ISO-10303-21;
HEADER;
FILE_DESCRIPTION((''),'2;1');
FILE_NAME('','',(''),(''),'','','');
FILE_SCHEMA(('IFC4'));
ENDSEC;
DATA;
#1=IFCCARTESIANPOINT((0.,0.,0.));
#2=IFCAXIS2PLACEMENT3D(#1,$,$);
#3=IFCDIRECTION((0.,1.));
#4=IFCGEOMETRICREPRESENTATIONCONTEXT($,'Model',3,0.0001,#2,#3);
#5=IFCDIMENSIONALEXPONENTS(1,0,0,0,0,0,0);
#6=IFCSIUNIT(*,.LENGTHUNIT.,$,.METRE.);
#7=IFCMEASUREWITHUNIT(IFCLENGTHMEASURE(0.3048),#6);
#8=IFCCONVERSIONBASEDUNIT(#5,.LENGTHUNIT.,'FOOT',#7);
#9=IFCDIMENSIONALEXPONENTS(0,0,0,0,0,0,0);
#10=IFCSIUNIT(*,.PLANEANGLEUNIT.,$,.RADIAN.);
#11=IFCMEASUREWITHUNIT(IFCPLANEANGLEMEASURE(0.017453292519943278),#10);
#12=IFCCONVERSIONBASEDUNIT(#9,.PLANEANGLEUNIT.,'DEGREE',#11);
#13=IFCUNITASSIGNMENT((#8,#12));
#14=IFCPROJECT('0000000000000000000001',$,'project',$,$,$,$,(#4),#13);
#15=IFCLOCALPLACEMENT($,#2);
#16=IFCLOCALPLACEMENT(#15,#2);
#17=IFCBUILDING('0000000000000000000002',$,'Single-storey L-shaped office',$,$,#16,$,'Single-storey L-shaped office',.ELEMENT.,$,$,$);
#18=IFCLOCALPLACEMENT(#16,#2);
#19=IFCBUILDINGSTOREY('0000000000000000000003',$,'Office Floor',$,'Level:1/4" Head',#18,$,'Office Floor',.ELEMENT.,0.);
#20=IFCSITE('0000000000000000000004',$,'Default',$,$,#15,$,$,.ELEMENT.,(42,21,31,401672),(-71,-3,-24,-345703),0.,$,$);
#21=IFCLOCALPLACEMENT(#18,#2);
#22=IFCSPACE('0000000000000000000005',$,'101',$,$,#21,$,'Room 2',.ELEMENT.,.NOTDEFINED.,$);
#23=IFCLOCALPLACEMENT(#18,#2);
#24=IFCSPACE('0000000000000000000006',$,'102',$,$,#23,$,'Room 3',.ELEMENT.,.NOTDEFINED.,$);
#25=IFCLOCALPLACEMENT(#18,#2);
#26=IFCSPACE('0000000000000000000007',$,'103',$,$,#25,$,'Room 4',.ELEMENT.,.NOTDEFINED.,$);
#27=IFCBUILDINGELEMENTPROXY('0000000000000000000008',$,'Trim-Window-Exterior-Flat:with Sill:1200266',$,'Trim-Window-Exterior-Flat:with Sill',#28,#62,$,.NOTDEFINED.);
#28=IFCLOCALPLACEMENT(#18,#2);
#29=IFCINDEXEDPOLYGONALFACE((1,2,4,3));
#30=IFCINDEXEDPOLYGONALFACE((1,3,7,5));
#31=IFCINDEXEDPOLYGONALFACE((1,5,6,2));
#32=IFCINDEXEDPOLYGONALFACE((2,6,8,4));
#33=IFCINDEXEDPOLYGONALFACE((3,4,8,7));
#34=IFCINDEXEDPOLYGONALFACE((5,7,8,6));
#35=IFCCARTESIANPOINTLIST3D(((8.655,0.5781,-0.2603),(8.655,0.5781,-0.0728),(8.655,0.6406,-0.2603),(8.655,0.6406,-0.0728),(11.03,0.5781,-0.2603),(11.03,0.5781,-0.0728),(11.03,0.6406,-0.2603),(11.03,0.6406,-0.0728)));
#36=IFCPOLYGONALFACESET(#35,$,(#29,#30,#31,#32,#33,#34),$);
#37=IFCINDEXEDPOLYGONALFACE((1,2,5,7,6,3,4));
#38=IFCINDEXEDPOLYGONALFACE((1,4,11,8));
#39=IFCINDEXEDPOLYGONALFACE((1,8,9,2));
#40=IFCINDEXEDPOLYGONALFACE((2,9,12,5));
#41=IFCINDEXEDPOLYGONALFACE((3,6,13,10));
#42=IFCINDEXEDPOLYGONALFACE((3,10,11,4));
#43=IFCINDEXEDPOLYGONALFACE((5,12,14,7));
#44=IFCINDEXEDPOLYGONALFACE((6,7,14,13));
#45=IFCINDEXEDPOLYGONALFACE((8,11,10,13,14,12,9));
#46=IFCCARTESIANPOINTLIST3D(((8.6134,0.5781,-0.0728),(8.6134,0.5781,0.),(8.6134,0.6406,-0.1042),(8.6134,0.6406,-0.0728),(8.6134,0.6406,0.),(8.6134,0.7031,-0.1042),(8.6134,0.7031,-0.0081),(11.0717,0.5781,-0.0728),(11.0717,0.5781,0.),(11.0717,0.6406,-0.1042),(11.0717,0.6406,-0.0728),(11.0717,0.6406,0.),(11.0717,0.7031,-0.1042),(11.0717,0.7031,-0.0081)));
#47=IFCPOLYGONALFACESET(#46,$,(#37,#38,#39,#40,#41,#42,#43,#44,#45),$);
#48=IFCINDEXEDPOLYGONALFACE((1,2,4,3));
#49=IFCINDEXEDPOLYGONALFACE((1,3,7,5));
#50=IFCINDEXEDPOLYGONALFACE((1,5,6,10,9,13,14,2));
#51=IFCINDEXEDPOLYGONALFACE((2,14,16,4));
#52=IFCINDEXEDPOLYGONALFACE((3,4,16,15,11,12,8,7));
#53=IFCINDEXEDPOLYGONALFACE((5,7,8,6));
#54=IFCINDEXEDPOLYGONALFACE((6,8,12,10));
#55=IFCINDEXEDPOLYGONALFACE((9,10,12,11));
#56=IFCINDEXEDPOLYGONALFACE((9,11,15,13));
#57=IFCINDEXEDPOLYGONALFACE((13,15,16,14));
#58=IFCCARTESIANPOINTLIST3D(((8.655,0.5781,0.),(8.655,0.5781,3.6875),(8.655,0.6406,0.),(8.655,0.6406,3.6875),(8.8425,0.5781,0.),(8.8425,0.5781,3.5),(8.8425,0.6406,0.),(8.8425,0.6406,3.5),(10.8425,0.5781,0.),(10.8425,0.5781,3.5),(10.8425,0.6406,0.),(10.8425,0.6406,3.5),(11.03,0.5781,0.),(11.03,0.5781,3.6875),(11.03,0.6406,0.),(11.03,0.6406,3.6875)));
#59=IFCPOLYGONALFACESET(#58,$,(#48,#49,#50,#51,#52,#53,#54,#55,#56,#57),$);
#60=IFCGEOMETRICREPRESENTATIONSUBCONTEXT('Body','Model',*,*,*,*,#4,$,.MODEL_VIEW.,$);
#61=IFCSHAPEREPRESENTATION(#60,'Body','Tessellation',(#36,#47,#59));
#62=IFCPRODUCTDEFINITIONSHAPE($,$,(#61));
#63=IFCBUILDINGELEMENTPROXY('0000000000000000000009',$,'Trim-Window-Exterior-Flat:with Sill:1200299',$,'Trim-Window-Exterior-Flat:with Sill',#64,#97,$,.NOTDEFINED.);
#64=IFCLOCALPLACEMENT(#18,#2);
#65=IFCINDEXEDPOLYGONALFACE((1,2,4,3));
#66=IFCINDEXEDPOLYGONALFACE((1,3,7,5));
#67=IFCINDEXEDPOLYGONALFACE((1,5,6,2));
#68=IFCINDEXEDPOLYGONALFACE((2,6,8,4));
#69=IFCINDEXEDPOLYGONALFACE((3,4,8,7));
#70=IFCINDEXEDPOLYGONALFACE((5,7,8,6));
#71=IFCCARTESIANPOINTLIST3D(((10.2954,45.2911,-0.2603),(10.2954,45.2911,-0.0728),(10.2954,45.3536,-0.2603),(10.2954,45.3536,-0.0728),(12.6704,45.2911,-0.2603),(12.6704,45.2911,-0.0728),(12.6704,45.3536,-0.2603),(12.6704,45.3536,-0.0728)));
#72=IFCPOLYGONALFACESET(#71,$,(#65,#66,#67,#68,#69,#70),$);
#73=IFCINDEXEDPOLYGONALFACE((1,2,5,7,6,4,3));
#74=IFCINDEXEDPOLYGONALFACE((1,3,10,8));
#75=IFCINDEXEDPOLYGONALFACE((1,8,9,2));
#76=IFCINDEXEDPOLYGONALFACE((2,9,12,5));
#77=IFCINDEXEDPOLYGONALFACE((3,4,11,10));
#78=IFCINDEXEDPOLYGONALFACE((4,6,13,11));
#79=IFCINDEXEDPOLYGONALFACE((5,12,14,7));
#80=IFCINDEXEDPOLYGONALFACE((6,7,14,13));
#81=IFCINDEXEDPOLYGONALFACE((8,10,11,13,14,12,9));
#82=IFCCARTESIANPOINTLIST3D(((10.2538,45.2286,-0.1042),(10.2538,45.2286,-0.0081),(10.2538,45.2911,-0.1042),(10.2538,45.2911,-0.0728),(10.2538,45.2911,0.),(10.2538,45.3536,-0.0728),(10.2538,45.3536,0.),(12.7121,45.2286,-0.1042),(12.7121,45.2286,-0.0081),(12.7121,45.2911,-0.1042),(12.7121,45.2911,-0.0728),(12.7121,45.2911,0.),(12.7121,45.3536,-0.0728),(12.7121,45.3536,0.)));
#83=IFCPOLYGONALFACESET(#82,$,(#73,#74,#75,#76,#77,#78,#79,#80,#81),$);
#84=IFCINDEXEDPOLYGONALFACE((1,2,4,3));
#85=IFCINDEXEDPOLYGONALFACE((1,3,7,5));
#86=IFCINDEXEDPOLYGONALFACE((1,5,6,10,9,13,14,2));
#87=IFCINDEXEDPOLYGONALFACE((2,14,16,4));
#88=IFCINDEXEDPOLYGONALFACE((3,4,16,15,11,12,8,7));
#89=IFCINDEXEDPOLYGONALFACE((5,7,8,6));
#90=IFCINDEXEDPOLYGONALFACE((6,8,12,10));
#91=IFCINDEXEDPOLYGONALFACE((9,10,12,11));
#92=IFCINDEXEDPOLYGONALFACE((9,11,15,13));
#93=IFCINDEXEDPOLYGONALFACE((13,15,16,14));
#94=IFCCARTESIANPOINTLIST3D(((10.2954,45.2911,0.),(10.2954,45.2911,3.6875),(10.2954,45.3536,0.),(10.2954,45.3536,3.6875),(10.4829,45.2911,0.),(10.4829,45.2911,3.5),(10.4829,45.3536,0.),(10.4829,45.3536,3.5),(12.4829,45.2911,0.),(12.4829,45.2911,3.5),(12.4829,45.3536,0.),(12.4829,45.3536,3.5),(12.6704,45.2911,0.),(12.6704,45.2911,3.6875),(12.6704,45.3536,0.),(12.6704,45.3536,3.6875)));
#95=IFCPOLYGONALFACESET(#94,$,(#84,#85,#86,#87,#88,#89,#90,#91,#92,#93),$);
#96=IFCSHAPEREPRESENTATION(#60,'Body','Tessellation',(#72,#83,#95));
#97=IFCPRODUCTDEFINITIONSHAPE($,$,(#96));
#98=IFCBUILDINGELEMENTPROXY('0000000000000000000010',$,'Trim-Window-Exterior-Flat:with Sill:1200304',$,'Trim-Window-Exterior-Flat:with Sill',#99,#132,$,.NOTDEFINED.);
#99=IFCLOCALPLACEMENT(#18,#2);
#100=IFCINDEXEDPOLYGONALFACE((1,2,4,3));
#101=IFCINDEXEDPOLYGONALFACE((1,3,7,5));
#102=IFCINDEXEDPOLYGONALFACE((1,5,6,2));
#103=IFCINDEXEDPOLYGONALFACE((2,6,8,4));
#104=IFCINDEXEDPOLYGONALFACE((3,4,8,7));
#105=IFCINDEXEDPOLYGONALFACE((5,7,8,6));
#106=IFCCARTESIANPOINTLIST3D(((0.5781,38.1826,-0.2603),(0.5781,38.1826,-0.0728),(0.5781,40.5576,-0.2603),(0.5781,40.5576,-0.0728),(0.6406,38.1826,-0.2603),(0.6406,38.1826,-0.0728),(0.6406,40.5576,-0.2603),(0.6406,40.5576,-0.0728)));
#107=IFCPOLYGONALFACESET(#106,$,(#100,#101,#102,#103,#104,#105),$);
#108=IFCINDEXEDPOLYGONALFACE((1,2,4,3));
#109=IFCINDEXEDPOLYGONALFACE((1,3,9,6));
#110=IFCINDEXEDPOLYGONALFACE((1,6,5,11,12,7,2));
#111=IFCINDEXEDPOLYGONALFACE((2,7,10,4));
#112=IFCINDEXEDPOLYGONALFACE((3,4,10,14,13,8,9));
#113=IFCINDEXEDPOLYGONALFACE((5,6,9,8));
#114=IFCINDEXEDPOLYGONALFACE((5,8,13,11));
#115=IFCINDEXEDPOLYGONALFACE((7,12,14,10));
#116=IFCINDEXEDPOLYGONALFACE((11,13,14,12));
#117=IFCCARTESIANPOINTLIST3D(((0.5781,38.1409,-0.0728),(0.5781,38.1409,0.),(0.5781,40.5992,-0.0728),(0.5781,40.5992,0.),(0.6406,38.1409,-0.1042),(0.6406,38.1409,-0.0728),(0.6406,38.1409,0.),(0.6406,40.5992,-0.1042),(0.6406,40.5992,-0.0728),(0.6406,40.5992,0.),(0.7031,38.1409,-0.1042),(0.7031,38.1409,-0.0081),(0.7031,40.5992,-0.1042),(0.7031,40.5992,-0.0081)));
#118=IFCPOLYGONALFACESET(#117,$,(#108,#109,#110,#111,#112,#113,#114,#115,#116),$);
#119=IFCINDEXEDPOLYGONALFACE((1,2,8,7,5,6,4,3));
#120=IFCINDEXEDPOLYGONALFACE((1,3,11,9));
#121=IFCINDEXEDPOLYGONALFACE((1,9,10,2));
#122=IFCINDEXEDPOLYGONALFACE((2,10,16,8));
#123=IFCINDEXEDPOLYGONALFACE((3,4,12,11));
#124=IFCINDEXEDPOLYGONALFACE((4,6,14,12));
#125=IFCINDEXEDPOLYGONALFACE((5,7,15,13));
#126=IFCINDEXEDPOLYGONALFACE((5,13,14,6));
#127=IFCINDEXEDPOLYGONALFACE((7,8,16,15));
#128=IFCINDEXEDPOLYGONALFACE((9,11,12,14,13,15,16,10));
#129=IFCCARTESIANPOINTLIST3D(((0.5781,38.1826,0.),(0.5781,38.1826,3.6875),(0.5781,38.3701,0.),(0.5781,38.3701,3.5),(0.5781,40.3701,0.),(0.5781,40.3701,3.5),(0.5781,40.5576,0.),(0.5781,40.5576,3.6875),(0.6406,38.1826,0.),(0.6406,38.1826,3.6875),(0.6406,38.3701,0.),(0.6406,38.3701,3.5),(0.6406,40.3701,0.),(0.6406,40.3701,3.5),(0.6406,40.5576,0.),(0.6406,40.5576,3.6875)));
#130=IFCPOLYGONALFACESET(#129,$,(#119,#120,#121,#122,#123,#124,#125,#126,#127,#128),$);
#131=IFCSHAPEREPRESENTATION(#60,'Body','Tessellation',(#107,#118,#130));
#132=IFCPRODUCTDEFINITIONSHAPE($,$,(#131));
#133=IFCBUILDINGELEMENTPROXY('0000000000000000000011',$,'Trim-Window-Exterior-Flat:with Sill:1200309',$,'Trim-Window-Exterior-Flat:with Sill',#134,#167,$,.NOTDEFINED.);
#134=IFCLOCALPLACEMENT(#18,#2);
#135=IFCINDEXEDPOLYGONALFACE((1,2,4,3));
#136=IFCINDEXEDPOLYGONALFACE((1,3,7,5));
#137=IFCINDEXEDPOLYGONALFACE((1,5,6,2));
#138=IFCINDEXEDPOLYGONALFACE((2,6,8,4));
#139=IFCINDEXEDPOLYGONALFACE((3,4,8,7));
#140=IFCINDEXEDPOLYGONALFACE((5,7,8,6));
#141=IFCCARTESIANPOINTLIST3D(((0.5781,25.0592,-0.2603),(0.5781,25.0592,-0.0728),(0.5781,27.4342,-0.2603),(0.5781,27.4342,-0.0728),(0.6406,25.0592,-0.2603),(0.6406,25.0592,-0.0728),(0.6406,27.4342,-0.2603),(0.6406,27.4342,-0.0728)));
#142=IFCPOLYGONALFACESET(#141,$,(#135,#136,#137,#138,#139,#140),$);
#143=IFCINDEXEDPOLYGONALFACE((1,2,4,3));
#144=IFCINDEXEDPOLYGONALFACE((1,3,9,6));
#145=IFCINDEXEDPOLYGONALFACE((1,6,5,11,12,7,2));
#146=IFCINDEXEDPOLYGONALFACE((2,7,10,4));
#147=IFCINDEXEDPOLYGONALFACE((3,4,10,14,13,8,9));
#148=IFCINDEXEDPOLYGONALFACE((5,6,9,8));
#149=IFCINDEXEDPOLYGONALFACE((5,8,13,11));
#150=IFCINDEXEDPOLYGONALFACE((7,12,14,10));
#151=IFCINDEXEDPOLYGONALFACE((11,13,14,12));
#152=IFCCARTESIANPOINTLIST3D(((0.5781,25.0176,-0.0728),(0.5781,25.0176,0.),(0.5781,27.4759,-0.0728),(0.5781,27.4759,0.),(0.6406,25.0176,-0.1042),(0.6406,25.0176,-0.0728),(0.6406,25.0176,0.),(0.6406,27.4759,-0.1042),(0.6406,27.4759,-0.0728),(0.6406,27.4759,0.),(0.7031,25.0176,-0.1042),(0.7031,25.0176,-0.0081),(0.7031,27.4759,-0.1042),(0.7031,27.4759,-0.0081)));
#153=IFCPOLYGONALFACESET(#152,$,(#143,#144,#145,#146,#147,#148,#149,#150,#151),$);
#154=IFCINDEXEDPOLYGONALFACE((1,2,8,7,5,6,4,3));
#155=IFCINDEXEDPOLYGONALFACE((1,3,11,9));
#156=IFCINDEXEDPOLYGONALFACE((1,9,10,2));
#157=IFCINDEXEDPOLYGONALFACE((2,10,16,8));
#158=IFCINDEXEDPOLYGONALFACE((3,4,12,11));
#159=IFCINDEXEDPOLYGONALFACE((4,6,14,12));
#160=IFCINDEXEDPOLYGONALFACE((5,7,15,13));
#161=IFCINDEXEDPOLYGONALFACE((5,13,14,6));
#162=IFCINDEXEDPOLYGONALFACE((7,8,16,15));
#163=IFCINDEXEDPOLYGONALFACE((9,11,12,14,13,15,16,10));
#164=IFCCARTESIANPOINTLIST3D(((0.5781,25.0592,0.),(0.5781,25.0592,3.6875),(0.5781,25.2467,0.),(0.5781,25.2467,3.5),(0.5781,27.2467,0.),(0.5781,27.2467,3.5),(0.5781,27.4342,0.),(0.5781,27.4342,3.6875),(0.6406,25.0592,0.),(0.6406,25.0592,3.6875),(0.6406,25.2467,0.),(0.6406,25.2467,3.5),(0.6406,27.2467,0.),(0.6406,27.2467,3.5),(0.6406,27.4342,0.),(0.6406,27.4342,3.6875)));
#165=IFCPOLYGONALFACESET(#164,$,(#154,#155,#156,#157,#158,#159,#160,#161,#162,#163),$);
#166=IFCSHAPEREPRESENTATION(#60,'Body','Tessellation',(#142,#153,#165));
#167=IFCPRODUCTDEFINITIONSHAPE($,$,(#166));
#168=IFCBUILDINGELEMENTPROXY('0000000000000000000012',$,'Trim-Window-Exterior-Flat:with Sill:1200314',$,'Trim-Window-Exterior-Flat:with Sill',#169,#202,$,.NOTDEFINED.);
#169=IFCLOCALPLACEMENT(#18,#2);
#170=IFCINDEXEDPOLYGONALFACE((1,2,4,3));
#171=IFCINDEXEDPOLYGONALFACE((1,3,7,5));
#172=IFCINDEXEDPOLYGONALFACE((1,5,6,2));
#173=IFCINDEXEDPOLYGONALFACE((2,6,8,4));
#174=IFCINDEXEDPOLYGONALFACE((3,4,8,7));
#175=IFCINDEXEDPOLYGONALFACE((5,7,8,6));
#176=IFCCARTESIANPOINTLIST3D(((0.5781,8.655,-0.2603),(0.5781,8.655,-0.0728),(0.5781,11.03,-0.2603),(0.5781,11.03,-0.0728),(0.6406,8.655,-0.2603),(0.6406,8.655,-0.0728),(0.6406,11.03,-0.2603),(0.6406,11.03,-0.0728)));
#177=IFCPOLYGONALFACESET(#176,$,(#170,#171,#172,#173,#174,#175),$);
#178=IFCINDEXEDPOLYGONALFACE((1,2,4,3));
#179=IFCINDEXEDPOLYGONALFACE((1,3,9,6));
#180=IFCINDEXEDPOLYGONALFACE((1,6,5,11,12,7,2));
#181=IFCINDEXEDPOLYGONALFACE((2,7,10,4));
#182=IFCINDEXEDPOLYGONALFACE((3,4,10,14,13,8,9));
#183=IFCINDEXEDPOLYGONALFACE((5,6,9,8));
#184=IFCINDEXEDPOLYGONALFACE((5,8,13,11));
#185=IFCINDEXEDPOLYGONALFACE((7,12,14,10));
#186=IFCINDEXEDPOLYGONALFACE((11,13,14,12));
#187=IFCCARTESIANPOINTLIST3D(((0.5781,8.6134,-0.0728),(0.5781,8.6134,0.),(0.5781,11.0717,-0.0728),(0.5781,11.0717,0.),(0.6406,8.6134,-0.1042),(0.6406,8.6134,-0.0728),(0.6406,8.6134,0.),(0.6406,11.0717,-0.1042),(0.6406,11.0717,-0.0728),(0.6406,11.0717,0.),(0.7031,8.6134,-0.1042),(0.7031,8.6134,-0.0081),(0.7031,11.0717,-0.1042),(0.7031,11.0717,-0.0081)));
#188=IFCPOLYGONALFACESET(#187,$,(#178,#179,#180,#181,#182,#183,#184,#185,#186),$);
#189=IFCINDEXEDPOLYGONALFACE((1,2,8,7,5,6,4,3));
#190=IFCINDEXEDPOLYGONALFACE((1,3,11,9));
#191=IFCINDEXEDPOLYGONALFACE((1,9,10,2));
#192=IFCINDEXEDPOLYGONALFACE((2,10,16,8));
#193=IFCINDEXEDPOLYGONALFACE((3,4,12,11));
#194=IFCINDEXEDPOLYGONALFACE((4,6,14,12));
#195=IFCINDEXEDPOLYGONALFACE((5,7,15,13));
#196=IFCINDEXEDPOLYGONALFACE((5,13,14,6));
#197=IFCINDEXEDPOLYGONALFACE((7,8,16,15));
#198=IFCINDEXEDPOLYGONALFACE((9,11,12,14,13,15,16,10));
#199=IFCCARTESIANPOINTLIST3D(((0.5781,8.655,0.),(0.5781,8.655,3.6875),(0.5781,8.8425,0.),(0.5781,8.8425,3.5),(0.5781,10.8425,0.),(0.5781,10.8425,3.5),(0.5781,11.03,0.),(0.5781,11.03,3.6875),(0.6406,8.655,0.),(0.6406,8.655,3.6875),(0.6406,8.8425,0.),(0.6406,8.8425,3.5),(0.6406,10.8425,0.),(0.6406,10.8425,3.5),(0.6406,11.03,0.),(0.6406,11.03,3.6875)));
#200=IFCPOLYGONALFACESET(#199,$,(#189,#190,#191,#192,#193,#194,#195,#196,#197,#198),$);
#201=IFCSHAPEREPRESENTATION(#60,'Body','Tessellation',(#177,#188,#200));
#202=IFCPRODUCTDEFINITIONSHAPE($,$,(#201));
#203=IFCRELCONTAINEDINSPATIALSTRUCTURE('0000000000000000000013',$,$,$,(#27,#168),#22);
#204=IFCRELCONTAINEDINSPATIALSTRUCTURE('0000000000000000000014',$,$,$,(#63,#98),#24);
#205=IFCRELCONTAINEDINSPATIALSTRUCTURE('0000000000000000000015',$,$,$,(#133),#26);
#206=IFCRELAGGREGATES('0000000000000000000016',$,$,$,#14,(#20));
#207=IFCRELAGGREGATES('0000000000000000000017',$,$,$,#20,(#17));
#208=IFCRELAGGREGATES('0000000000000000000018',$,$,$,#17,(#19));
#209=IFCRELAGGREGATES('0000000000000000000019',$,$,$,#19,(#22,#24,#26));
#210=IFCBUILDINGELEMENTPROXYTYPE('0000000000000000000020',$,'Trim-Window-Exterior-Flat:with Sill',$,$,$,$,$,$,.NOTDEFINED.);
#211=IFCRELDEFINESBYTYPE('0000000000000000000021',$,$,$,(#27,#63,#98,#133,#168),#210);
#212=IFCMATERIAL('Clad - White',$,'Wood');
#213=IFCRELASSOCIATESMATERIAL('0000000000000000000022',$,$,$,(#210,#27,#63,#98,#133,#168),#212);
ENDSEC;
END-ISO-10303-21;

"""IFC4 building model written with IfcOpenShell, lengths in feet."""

from ifc_helpers import new_model, entity, si_unit, converted_unit, direction, frame, origin, place, context, subcontext, project, spatial, indexed_curve, outline, extrude, source, transform, mapped, material, type_object, type_shapes, element, save


model = new_model("IFC4")

# Units and contexts
model_context = context("Model", 3, precision=0.0001, world=origin(), true_north=direction((0.0, 1.0)))
body_context = subcontext(model_context, "Body", "Model", "MODEL_VIEW")
ifc_project = project(units=[converted_unit("LENGTHUNIT", "FOOT", entity("IfcLengthMeasure", 0.3048), si_unit("LENGTHUNIT", "METRE"), dimensions=[1, 0, 0, 0, 0, 0, 0]), converted_unit("PLANEANGLEUNIT", "DEGREE", entity("IfcPlaneAngleMeasure", 0.017453292519943278), si_unit("PLANEANGLEUNIT", "RADIAN"), dimensions=[0, 0, 0, 0, 0, 0, 0])], contexts=[model_context])

# Site, building, storey
site_placement = place(None, origin())
site = spatial("IfcSite", under=ifc_project, at=site_placement, Name="Default", CompositionType="ELEMENT", RefLatitude=(42, 21, 31, 401672), RefLongitude=(-71, -3, -24, -345703), RefElevation=0.0)
building_placement = place(site_placement, origin())
building = spatial("IfcBuilding", under=site, at=building_placement, Name="Single-storey L-shaped office", LongName="Single-storey L-shaped office", CompositionType="ELEMENT")
storey_placement = place(building_placement, origin())
storey = spatial("IfcBuildingStorey", under=building, at=storey_placement, Name="Office Floor", ObjectType="Level:1/4\" Head", LongName="Office Floor", CompositionType="ELEMENT", Elevation=0.0)

# Shared definitions
ifc_material_1 = material(Name="Clad - White", Category="Wood")

# Shared definitions
space_1_placement = place(storey_placement, origin())
space_1 = spatial("IfcSpace", under=storey, at=space_1_placement, Name="101", LongName="Room 2", CompositionType="ELEMENT", PredefinedType="NOTDEFINED")

# Building element proxy
building_element_proxy_type_1 = type_object("IfcBuildingElementProxyType", Name="Trim-Window-Exterior-Flat:with Sill", PredefinedType="NOTDEFINED", material=ifc_material_1)
shared_shape_1 = source(origin(), body_context, "Body", "SweptSolid", [
    extrude(outline(indexed_curve([(-1.1875, -0.0938), (1.1875, -0.0938), (1.1875, 0.0938), (-1.1875, 0.0938), (-1.1875, -0.0938)], self_intersect=False)), frame((0.0, -3.6665, 0.0), z_axis=(0.0, 0.0, 1.0), x_axis=(-1.0, 0.0, 0.0)), (0.0, 0.0, 1.0), 0.0625),
    extrude(outline(indexed_curve([(-0.0625, -0.0525), (0.0, -0.0525), (0.0, -0.0211), (0.0625, -0.0211), (0.0625, 0.0517), (0.0, 0.0517), (-0.0625, 0.0436), (-0.0625, -0.0525)], self_intersect=False)), frame((-1.2292, -3.5517, 0.0625), z_axis=(1.0, 0.0, 0.0), x_axis=(0.0, 0.0, -1.0)), (0.0, 0.0, 1.0), 2.4583),
    extrude(outline(indexed_curve([(-1.8906, -1.1875), (1.7969, -1.1875), (1.7969, -1.0), (-1.7031, -1.0), (-1.7031, 1.0), (1.7969, 1.0), (1.7969, 1.1875), (-1.8906, 1.1875), (-1.8906, -1.1875)], self_intersect=False)), frame((0.0, -1.7031, 0.0), z_axis=(0.0, 0.0, 1.0), x_axis=(0.0, -1.0, 0.0)), (0.0, 0.0, 1.0), 0.0625),
])
type_shapes(building_element_proxy_type_1, [shared_shape_1])
proxy_1_placement = place(space_1_placement, frame((9.8425, 0.5781, 3.5), z_axis=(0.0, 1.0, 0.0), x_axis=(-1.0, 0.0, 0.0)))
element("IfcBuildingElementProxy", 1, at=proxy_1_placement, inside=space_1, type_object=building_element_proxy_type_1, material=ifc_material_1, Name="Trim-Window-Exterior-Flat:with Sill:1200266", ObjectType="Trim-Window-Exterior-Flat:with Sill", PredefinedType="NOTDEFINED", context=body_context, shape_type="MappedRepresentation", body=[
    mapped(shared_shape_1, transform((0.0, 0.0, 0.0), scale=1.0)),
])

# Shared definitions
space_2_placement = place(storey_placement, origin())
space_2 = spatial("IfcSpace", under=storey, at=space_2_placement, Name="102", LongName="Room 3", CompositionType="ELEMENT", PredefinedType="NOTDEFINED")

# Building element proxies
for number, where, z_axis, x_axis, name in (
    (2, (11.4829, 45.3536, 3.5), (0.0, -1.0, 0.0), (1.0, 0.0, 0.0), "Trim-Window-Exterior-Flat:with Sill:1200299"),
    (3, (0.5781, 39.3701, 3.5), (1.0, 0.0, 0.0), (0.0, 1.0, 0.0), "Trim-Window-Exterior-Flat:with Sill:1200304"),
):
    element("IfcBuildingElementProxy", number, at=place(space_2_placement, frame(where, z_axis=z_axis, x_axis=x_axis)), inside=space_2, type_object=building_element_proxy_type_1, material=ifc_material_1, Name=name, ObjectType="Trim-Window-Exterior-Flat:with Sill", PredefinedType="NOTDEFINED", context=body_context, shape_type="MappedRepresentation", body=[
        mapped(shared_shape_1, transform((0.0, 0.0, 0.0), scale=1.0)),
    ])

# Shared definitions
space_3_placement = place(storey_placement, origin())
space_3 = spatial("IfcSpace", under=storey, at=space_3_placement, Name="103", LongName="Room 4", CompositionType="ELEMENT", PredefinedType="NOTDEFINED")

# Building element proxies
proxy_2_placement = place(space_3_placement, frame((0.5781, 26.2467, 3.5), z_axis=(1.0, 0.0, 0.0), x_axis=(0.0, 1.0, 0.0)))
element("IfcBuildingElementProxy", 4, at=proxy_2_placement, inside=space_3, type_object=building_element_proxy_type_1, material=ifc_material_1, Name="Trim-Window-Exterior-Flat:with Sill:1200309", ObjectType="Trim-Window-Exterior-Flat:with Sill", PredefinedType="NOTDEFINED", context=body_context, shape_type="MappedRepresentation", body=[
    mapped(shared_shape_1, transform((0.0, 0.0, 0.0), scale=1.0)),
])
proxy_3_placement = place(space_1_placement, frame((0.5781, 9.8425, 3.5), z_axis=(1.0, 0.0, 0.0), x_axis=(0.0, 1.0, 0.0)))
element("IfcBuildingElementProxy", 5, at=proxy_3_placement, inside=space_1, type_object=building_element_proxy_type_1, material=ifc_material_1, Name="Trim-Window-Exterior-Flat:with Sill:1200314", ObjectType="Trim-Window-Exterior-Flat:with Sill", PredefinedType="NOTDEFINED", context=body_context, shape_type="MappedRepresentation", body=[
    mapped(shared_shape_1, transform((0.0, 0.0, 0.0), scale=1.0)),
])

save(model, "model.ifc")
